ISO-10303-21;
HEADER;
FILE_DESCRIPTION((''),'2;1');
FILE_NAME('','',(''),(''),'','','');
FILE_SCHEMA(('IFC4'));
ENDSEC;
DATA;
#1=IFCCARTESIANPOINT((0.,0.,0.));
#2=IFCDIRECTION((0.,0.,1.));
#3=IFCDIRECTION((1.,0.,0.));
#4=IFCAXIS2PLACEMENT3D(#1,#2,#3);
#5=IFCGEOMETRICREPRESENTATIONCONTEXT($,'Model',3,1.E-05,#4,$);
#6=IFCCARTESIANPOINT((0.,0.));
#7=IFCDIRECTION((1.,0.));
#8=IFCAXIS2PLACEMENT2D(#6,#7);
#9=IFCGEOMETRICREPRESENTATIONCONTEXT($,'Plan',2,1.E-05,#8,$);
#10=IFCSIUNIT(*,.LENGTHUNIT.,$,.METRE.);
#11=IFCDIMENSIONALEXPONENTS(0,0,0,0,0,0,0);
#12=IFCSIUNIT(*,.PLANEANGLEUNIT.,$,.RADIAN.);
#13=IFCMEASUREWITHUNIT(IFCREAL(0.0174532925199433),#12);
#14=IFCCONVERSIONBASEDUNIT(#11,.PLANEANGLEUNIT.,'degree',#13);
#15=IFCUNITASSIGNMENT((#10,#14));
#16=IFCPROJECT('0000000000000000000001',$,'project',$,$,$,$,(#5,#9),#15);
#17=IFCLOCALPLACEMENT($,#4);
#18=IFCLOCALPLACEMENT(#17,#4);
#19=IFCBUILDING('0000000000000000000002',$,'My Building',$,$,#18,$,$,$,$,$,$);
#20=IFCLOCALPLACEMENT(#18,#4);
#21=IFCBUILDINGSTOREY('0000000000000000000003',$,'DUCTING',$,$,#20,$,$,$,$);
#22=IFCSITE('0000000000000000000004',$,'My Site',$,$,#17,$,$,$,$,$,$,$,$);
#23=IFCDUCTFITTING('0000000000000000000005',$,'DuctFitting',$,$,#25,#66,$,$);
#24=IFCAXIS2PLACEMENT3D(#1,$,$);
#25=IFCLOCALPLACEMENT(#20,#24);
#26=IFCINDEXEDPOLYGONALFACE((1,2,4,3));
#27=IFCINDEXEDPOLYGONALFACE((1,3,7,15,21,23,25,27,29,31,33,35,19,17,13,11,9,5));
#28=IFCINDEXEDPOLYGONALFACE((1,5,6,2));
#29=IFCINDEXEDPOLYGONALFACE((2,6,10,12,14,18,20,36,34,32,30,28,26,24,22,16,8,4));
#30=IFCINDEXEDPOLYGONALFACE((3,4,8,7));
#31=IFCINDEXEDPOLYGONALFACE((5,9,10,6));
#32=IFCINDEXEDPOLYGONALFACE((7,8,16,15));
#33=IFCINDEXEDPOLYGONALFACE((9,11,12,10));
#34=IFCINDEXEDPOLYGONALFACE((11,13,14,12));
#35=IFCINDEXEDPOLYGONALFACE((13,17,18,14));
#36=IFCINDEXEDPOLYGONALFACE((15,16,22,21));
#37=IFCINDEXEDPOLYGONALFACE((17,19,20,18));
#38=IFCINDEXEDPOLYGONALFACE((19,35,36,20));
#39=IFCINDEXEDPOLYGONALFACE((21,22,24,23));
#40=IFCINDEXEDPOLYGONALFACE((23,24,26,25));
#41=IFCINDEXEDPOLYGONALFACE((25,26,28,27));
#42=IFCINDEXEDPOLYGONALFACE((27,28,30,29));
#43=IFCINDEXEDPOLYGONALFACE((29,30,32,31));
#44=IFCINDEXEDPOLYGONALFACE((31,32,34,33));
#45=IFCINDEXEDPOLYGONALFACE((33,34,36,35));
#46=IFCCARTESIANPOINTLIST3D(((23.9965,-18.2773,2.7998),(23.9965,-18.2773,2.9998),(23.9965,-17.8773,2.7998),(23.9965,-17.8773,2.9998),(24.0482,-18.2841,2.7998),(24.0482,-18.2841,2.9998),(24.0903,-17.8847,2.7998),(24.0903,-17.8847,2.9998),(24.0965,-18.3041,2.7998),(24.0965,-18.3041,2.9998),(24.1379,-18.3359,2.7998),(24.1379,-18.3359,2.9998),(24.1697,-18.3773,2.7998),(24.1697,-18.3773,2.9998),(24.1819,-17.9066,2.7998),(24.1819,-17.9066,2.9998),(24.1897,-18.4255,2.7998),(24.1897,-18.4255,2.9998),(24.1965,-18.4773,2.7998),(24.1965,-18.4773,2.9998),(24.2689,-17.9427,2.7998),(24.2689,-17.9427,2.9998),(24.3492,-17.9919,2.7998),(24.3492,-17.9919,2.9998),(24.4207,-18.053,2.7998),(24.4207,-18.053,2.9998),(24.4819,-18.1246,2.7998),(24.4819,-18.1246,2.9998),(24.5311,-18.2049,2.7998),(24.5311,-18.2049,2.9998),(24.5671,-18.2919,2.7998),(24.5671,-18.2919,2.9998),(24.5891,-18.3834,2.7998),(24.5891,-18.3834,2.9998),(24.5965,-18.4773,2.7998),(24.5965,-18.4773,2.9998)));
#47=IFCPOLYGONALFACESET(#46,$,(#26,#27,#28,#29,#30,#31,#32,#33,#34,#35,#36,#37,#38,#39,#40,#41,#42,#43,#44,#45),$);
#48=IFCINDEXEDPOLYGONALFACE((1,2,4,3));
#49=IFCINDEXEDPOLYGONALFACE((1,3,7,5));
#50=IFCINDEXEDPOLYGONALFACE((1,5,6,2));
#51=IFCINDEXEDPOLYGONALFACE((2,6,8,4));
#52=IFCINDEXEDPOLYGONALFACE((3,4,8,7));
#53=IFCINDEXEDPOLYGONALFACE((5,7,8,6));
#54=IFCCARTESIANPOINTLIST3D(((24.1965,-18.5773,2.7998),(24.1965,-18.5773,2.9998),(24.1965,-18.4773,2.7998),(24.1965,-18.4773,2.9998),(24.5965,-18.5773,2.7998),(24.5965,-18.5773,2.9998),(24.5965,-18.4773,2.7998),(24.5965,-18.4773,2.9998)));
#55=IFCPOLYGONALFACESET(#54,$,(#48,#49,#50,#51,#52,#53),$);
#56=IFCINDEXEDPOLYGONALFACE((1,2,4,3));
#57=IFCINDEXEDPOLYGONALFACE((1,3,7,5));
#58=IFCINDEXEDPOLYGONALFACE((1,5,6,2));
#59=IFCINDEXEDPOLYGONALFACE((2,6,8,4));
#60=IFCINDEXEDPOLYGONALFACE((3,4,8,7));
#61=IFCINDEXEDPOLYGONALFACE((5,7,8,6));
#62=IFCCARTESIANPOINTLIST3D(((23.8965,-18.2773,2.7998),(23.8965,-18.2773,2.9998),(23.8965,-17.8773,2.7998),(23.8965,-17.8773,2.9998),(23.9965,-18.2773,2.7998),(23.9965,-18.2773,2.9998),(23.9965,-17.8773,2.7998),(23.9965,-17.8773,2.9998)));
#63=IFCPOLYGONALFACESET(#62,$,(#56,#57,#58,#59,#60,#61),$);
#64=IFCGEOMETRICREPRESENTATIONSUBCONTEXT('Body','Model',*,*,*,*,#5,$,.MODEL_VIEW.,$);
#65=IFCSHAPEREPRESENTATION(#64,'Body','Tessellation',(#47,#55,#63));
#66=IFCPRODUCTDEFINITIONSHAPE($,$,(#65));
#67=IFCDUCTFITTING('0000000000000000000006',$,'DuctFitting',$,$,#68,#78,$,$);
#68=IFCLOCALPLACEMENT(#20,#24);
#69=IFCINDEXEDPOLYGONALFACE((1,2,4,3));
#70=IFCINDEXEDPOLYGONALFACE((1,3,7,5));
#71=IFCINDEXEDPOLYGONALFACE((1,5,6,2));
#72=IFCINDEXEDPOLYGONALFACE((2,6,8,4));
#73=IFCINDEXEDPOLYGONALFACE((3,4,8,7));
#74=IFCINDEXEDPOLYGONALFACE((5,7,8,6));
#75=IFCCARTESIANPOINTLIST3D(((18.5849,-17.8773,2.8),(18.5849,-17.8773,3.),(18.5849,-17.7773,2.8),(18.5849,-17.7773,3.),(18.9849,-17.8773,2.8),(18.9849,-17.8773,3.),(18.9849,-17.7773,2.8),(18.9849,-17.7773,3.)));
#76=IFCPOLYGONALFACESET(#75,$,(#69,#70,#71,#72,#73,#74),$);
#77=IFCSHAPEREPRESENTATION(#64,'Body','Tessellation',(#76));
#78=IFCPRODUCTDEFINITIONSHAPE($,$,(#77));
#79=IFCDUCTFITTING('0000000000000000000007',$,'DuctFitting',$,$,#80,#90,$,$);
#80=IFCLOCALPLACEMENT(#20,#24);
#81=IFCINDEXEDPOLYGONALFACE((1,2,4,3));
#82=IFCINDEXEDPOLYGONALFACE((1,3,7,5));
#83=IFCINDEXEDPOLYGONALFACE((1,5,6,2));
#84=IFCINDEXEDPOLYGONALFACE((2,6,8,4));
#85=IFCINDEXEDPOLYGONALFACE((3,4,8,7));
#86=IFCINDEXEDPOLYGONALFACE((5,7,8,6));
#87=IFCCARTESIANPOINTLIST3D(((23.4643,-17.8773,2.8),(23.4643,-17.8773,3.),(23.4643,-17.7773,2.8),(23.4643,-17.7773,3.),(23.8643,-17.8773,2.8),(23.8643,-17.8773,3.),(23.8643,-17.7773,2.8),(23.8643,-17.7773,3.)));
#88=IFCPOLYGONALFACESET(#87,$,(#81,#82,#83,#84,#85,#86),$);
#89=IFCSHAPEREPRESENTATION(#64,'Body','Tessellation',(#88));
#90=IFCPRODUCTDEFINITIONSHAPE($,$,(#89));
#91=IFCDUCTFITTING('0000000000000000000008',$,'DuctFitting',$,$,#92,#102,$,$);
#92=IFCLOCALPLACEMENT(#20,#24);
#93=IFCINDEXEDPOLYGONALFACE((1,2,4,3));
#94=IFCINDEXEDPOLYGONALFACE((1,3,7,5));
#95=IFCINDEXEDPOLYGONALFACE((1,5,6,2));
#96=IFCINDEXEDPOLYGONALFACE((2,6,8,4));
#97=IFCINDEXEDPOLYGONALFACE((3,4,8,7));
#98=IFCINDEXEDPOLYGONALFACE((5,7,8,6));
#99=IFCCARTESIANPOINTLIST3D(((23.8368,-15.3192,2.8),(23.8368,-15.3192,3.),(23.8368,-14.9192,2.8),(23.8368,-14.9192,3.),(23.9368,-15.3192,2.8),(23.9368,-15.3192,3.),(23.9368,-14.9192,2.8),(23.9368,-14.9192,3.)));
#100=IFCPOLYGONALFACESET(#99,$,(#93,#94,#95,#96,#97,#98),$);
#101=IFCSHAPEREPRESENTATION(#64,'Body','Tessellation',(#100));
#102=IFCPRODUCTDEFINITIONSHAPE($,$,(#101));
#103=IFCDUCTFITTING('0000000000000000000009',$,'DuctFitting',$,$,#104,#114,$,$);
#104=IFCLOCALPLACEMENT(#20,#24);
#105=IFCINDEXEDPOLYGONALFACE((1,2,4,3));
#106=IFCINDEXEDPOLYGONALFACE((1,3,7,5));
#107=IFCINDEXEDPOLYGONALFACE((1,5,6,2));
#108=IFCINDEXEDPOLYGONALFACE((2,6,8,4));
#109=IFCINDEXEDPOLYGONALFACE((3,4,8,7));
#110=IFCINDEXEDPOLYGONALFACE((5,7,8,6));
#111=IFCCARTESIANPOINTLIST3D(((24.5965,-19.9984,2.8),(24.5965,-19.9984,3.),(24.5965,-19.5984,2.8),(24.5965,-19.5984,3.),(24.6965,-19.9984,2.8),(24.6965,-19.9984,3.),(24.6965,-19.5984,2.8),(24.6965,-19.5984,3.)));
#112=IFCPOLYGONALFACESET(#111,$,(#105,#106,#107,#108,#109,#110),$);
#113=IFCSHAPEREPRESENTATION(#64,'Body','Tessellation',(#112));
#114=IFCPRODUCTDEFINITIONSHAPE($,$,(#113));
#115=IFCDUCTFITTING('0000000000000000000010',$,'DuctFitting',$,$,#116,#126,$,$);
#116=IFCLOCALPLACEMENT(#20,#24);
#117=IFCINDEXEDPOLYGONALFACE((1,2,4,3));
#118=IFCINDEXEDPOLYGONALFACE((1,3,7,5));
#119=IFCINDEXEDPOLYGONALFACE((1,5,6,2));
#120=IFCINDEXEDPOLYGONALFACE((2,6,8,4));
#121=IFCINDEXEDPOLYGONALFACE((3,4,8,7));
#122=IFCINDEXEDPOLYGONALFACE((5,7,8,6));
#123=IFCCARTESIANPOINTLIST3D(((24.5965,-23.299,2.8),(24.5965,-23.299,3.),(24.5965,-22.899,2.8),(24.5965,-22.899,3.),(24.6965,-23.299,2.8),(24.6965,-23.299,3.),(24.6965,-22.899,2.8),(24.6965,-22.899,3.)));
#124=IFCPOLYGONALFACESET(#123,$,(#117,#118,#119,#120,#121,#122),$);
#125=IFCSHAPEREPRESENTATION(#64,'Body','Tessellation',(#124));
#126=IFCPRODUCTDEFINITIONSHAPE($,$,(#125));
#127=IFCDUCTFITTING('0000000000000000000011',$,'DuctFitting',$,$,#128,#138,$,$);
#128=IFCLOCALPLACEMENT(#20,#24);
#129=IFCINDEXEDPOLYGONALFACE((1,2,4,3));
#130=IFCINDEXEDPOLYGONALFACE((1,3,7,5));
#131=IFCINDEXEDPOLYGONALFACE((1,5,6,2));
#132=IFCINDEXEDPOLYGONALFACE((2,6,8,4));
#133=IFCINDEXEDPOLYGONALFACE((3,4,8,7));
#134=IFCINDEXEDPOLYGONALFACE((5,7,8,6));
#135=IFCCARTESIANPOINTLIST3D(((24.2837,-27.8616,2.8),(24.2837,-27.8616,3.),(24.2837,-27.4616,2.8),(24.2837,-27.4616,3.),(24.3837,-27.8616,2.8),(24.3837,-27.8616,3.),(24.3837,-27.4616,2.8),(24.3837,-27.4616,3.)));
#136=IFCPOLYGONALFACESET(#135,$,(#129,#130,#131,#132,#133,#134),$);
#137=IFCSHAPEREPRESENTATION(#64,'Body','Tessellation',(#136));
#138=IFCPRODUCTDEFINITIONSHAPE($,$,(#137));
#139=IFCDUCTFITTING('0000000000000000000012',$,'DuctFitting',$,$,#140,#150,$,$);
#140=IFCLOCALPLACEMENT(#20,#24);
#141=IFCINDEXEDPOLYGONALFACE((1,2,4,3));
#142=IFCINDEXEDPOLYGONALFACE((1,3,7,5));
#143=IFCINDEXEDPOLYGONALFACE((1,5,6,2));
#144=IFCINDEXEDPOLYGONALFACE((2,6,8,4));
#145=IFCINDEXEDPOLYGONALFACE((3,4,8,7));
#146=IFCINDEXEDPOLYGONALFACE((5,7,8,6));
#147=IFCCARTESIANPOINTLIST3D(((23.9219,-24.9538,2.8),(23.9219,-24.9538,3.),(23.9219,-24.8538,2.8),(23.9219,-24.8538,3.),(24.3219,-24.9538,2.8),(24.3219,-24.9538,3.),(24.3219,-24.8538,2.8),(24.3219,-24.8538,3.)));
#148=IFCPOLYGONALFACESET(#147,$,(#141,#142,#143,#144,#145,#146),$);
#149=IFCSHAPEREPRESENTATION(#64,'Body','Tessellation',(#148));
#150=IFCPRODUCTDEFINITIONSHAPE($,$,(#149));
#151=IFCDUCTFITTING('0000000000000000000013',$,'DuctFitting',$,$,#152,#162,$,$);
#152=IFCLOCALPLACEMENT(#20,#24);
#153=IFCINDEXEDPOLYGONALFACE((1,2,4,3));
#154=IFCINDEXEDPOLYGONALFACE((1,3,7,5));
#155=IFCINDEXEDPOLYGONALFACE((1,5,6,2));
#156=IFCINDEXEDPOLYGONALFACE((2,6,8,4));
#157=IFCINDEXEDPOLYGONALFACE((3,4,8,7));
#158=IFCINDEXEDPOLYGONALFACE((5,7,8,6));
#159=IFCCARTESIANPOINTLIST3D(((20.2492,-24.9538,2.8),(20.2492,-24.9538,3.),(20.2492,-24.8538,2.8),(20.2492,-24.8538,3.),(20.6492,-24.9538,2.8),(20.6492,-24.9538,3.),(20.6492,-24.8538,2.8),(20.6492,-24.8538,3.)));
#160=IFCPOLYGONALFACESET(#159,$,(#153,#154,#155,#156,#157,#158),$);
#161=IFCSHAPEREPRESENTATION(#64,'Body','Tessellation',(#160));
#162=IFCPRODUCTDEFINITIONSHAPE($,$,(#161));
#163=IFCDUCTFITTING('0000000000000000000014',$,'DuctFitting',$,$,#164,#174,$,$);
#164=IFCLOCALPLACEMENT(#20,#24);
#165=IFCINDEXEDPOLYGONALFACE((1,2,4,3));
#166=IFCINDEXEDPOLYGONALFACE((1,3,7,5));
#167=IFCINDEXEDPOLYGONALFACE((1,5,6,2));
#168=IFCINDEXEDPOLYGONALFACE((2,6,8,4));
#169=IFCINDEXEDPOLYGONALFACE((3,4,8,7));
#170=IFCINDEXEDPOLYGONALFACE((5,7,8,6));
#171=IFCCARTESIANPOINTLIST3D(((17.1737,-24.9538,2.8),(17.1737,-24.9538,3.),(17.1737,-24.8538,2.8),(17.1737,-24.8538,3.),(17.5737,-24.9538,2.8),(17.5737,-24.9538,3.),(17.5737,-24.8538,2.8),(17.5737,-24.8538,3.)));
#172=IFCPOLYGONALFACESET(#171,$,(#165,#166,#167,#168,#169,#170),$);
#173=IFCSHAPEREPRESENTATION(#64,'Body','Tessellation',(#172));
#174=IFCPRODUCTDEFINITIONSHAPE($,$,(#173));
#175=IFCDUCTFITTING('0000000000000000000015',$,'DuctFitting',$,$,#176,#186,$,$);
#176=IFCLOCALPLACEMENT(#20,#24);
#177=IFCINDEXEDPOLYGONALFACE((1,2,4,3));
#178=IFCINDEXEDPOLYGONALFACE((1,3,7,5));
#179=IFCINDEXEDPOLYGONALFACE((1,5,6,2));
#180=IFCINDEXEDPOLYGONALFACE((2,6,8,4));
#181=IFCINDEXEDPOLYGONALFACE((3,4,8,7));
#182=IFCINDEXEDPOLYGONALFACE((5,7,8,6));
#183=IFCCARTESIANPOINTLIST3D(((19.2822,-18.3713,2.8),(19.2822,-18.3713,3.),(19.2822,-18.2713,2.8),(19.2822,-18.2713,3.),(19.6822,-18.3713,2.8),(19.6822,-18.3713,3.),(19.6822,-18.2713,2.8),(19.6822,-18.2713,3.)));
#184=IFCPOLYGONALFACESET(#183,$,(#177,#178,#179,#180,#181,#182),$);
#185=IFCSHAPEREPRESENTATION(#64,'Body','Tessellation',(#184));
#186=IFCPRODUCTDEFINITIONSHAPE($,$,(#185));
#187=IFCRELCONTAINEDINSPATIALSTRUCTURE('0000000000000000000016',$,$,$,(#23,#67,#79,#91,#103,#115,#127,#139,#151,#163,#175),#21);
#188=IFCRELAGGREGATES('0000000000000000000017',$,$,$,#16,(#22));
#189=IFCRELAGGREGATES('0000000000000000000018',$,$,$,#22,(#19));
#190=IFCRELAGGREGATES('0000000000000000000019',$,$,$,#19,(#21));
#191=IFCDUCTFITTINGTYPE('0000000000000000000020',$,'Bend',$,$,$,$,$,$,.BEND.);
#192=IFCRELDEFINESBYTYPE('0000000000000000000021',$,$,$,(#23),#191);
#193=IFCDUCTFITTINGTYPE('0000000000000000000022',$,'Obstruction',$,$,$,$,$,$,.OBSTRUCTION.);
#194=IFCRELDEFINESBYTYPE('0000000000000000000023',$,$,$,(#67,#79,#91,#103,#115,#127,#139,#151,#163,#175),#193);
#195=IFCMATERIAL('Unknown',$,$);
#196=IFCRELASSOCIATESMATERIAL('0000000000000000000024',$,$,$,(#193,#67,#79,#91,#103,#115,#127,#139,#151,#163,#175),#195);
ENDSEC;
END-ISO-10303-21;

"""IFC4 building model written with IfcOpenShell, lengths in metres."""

from ifc_helpers import new_model, entity, si_unit, converted_unit, frame, origin_with_axes, origin_2d_with_axis, place, context, subcontext, project, spatial, line, arc, indexed_curve, rectangle, outline, extrude, source, transform, mapped, material, material_profile, profile_set, profile_usage, type_object, type_shapes, element, save


model = new_model("IFC4")

# Units and contexts
model_context = context("Model", 3, precision=1e-05, world=origin_with_axes())
plan_context = context("Plan", 2, precision=1e-05, world=origin_2d_with_axis())
body_context = subcontext(model_context, "Body", "Model", "MODEL_VIEW")
ifc_project = project(units=[si_unit("LENGTHUNIT", "METRE"), converted_unit("PLANEANGLEUNIT", "degree", entity("IfcReal", 0.0174532925199433), si_unit("PLANEANGLEUNIT", "RADIAN"), dimensions=[0, 0, 0, 0, 0, 0, 0])], contexts=[model_context, plan_context])

# Site, building, storey
site_placement = place(None, origin_with_axes())
site = spatial("IfcSite", under=ifc_project, at=site_placement, Name="My Site")
building_placement = place(site_placement, origin_with_axes())
building = spatial("IfcBuilding", under=site, at=building_placement, Name="My Building")
storey_placement = place(building_placement, origin_with_axes())
storey = spatial("IfcBuildingStorey", under=building, at=storey_placement, Name="DUCTING")

# Shared definitions
ifc_material = material(Name="Unknown")

# Duct fittings
duct_fitting_type_1 = type_object("IfcDuctFittingType", Name="Bend", PredefinedType="BEND")
shared_shape = source(origin_with_axes(), body_context, "Body", "SweptSolid", [
    extrude(outline(indexed_curve([(-0.2, 0.0), (-0.2586, 0.1414), (-0.4, 0.2), (-0.4, 0.6), (0.0243, 0.4243), (0.2, 0.0)], segments=[arc(1, 2, 3), line(3, 4), arc(4, 5, 6), line(6, 1)])), frame((0.0, -0.1, 0.1), z_axis=(0.0, -1.0, 0.0), x_axis=(1.0, 0.0, 0.0)), (0.0, 0.0, -1.0), 0.2),
    extrude(rectangle(XDim=0.4, YDim=0.2), origin_with_axes(), (0.0, 0.0, 1.0), 0.1),
    extrude(rectangle(XDim=0.4, YDim=0.2), frame((-0.4, 0.0, 0.5), z_axis=(-1.0, 0.0, 0.0), x_axis=(0.0, 0.0, -1.0)), (0.0, 0.0, 1.0), 0.1),
])
type_shapes(duct_fitting_type_1, [shared_shape])
for number, where, z_axis, x_axis, name in (
    (1, (24.3965, -18.5773, 2.8998), (0.0, 1.0, 0.0), (1.0, 0.0, 0.0), "DuctFitting"),
):
    element("IfcDuctFitting", number, at=place(storey_placement, frame(where, z_axis=z_axis, x_axis=x_axis)), inside=storey, type_object=duct_fitting_type_1, Name=name, context=body_context, shape_type="MappedRepresentation", body=[
        mapped(shared_shape, transform((0.0, 0.0, 0.0), x_axis=(1.0, 0.0, 0.0), y_axis=(0.0, 1.0, 0.0), z_axis=(0.0, 0.0, 1.0), scale=1.0)),
    ])
ifc_material_profile_1 = material_profile(ifc_material, rectangle(XDim=0.4, YDim=0.2))
ifc_profile_set_1 = profile_set([ifc_material_profile_1])
ifc_profile_usage_1 = profile_usage(ifc_profile_set_1, cardinal=5)
duct_fitting_type_2 = type_object("IfcDuctFittingType", Name="Obstruction", PredefinedType="OBSTRUCTION", material=ifc_profile_set_1)
duct_fitting_1_placement = place(storey_placement, frame((18.7849, -17.8773, 2.9), z_axis=(0.0, 1.0, 0.0), x_axis=(-1.0, 0.0, 0.0)))
element("IfcDuctFitting", 2, at=duct_fitting_1_placement, inside=storey, type_object=duct_fitting_type_2, material=ifc_profile_usage_1, Name="DuctFitting", context=body_context, shape_type="SweptSolid", body=[
    extrude(rectangle(XDim=0.4, YDim=0.2), origin_with_axes(), (0.0, 0.0, 1.0), 0.1),
])
ifc_profile_usage_2 = profile_usage(ifc_profile_set_1, cardinal=5)
duct_fitting_2_placement = place(storey_placement, frame((23.6643, -17.8773, 2.9), z_axis=(0.0, 1.0, 0.0), x_axis=(-1.0, 0.0, 0.0)))
element("IfcDuctFitting", 3, at=duct_fitting_2_placement, inside=storey, type_object=duct_fitting_type_2, material=ifc_profile_usage_2, Name="DuctFitting", context=body_context, shape_type="SweptSolid", body=[
    extrude(rectangle(XDim=0.4, YDim=0.2), origin_with_axes(), (0.0, 0.0, 1.0), 0.1),
])
ifc_profile_usage_3 = profile_usage(ifc_profile_set_1, cardinal=5)
duct_fitting_3_placement = place(storey_placement, frame((23.8368, -15.1192, 2.9), z_axis=(1.0, 0.0, 0.0), x_axis=(0.0, 1.0, 0.0)))
element("IfcDuctFitting", 4, at=duct_fitting_3_placement, inside=storey, type_object=duct_fitting_type_2, material=ifc_profile_usage_3, Name="DuctFitting", context=body_context, shape_type="SweptSolid", body=[
    extrude(rectangle(XDim=0.4, YDim=0.2), origin_with_axes(), (0.0, 0.0, 1.0), 0.1),
])
ifc_profile_usage_4 = profile_usage(ifc_profile_set_1, cardinal=5)
duct_fitting_4_placement = place(storey_placement, frame((24.5965, -19.7984, 2.9), z_axis=(1.0, 0.0, 0.0), x_axis=(0.0, 1.0, 0.0)))
element("IfcDuctFitting", 5, at=duct_fitting_4_placement, inside=storey, type_object=duct_fitting_type_2, material=ifc_profile_usage_4, Name="DuctFitting", context=body_context, shape_type="SweptSolid", body=[
    extrude(rectangle(XDim=0.4, YDim=0.2), origin_with_axes(), (0.0, 0.0, 1.0), 0.1),
])
ifc_profile_usage_5 = profile_usage(ifc_profile_set_1, cardinal=5)
duct_fitting_5_placement = place(storey_placement, frame((24.5965, -23.099, 2.9), z_axis=(1.0, 0.0, 0.0), x_axis=(0.0, 1.0, 0.0)))
element("IfcDuctFitting", 6, at=duct_fitting_5_placement, inside=storey, type_object=duct_fitting_type_2, material=ifc_profile_usage_5, Name="DuctFitting", context=body_context, shape_type="SweptSolid", body=[
    extrude(rectangle(XDim=0.4, YDim=0.2), origin_with_axes(), (0.0, 0.0, 1.0), 0.1),
])
ifc_profile_usage_6 = profile_usage(ifc_profile_set_1, cardinal=5)
duct_fitting_6_placement = place(storey_placement, frame((24.2837, -27.6616, 2.9), z_axis=(1.0, 0.0, 0.0), x_axis=(0.0, 1.0, 0.0)))
element("IfcDuctFitting", 7, at=duct_fitting_6_placement, inside=storey, type_object=duct_fitting_type_2, material=ifc_profile_usage_6, Name="DuctFitting", context=body_context, shape_type="SweptSolid", body=[
    extrude(rectangle(XDim=0.4, YDim=0.2), origin_with_axes(), (0.0, 0.0, 1.0), 0.1),
])
ifc_profile_usage_7 = profile_usage(ifc_profile_set_1, cardinal=5)
duct_fitting_7_placement = place(storey_placement, frame((24.1219, -24.8538, 2.9), z_axis=(0.0, -1.0, 0.0), x_axis=(1.0, 0.0, 0.0)))
element("IfcDuctFitting", 8, at=duct_fitting_7_placement, inside=storey, type_object=duct_fitting_type_2, material=ifc_profile_usage_7, Name="DuctFitting", context=body_context, shape_type="SweptSolid", body=[
    extrude(rectangle(XDim=0.4, YDim=0.2), origin_with_axes(), (0.0, 0.0, 1.0), 0.1),
])
ifc_profile_usage_8 = profile_usage(ifc_profile_set_1, cardinal=5)
duct_fitting_8_placement = place(storey_placement, frame((20.4492, -24.8538, 2.9), z_axis=(0.0, -1.0, 0.0), x_axis=(1.0, 0.0, 0.0)))
element("IfcDuctFitting", 9, at=duct_fitting_8_placement, inside=storey, type_object=duct_fitting_type_2, material=ifc_profile_usage_8, Name="DuctFitting", context=body_context, shape_type="SweptSolid", body=[
    extrude(rectangle(XDim=0.4, YDim=0.2), origin_with_axes(), (0.0, 0.0, 1.0), 0.1),
])
ifc_profile_usage_9 = profile_usage(ifc_profile_set_1, cardinal=5)
duct_fitting_9_placement = place(storey_placement, frame((17.3737, -24.8538, 2.9), z_axis=(0.0, -1.0, 0.0), x_axis=(1.0, 0.0, 0.0)))
element("IfcDuctFitting", 10, at=duct_fitting_9_placement, inside=storey, type_object=duct_fitting_type_2, material=ifc_profile_usage_9, Name="DuctFitting", context=body_context, shape_type="SweptSolid", body=[
    extrude(rectangle(XDim=0.4, YDim=0.2), origin_with_axes(), (0.0, 0.0, 1.0), 0.1),
])
ifc_profile_usage_10 = profile_usage(ifc_profile_set_1, cardinal=5)
duct_fitting_10_placement = place(storey_placement, frame((19.4822, -18.2713, 2.9), z_axis=(0.0, -1.0, 0.0), x_axis=(1.0, 0.0, 0.0)))
element("IfcDuctFitting", 11, at=duct_fitting_10_placement, inside=storey, type_object=duct_fitting_type_2, material=ifc_profile_usage_10, Name="DuctFitting", context=body_context, shape_type="SweptSolid", body=[
    extrude(rectangle(XDim=0.4, YDim=0.2), origin_with_axes(), (0.0, 0.0, 1.0), 0.1),
])

save(model, "model.ifc")
